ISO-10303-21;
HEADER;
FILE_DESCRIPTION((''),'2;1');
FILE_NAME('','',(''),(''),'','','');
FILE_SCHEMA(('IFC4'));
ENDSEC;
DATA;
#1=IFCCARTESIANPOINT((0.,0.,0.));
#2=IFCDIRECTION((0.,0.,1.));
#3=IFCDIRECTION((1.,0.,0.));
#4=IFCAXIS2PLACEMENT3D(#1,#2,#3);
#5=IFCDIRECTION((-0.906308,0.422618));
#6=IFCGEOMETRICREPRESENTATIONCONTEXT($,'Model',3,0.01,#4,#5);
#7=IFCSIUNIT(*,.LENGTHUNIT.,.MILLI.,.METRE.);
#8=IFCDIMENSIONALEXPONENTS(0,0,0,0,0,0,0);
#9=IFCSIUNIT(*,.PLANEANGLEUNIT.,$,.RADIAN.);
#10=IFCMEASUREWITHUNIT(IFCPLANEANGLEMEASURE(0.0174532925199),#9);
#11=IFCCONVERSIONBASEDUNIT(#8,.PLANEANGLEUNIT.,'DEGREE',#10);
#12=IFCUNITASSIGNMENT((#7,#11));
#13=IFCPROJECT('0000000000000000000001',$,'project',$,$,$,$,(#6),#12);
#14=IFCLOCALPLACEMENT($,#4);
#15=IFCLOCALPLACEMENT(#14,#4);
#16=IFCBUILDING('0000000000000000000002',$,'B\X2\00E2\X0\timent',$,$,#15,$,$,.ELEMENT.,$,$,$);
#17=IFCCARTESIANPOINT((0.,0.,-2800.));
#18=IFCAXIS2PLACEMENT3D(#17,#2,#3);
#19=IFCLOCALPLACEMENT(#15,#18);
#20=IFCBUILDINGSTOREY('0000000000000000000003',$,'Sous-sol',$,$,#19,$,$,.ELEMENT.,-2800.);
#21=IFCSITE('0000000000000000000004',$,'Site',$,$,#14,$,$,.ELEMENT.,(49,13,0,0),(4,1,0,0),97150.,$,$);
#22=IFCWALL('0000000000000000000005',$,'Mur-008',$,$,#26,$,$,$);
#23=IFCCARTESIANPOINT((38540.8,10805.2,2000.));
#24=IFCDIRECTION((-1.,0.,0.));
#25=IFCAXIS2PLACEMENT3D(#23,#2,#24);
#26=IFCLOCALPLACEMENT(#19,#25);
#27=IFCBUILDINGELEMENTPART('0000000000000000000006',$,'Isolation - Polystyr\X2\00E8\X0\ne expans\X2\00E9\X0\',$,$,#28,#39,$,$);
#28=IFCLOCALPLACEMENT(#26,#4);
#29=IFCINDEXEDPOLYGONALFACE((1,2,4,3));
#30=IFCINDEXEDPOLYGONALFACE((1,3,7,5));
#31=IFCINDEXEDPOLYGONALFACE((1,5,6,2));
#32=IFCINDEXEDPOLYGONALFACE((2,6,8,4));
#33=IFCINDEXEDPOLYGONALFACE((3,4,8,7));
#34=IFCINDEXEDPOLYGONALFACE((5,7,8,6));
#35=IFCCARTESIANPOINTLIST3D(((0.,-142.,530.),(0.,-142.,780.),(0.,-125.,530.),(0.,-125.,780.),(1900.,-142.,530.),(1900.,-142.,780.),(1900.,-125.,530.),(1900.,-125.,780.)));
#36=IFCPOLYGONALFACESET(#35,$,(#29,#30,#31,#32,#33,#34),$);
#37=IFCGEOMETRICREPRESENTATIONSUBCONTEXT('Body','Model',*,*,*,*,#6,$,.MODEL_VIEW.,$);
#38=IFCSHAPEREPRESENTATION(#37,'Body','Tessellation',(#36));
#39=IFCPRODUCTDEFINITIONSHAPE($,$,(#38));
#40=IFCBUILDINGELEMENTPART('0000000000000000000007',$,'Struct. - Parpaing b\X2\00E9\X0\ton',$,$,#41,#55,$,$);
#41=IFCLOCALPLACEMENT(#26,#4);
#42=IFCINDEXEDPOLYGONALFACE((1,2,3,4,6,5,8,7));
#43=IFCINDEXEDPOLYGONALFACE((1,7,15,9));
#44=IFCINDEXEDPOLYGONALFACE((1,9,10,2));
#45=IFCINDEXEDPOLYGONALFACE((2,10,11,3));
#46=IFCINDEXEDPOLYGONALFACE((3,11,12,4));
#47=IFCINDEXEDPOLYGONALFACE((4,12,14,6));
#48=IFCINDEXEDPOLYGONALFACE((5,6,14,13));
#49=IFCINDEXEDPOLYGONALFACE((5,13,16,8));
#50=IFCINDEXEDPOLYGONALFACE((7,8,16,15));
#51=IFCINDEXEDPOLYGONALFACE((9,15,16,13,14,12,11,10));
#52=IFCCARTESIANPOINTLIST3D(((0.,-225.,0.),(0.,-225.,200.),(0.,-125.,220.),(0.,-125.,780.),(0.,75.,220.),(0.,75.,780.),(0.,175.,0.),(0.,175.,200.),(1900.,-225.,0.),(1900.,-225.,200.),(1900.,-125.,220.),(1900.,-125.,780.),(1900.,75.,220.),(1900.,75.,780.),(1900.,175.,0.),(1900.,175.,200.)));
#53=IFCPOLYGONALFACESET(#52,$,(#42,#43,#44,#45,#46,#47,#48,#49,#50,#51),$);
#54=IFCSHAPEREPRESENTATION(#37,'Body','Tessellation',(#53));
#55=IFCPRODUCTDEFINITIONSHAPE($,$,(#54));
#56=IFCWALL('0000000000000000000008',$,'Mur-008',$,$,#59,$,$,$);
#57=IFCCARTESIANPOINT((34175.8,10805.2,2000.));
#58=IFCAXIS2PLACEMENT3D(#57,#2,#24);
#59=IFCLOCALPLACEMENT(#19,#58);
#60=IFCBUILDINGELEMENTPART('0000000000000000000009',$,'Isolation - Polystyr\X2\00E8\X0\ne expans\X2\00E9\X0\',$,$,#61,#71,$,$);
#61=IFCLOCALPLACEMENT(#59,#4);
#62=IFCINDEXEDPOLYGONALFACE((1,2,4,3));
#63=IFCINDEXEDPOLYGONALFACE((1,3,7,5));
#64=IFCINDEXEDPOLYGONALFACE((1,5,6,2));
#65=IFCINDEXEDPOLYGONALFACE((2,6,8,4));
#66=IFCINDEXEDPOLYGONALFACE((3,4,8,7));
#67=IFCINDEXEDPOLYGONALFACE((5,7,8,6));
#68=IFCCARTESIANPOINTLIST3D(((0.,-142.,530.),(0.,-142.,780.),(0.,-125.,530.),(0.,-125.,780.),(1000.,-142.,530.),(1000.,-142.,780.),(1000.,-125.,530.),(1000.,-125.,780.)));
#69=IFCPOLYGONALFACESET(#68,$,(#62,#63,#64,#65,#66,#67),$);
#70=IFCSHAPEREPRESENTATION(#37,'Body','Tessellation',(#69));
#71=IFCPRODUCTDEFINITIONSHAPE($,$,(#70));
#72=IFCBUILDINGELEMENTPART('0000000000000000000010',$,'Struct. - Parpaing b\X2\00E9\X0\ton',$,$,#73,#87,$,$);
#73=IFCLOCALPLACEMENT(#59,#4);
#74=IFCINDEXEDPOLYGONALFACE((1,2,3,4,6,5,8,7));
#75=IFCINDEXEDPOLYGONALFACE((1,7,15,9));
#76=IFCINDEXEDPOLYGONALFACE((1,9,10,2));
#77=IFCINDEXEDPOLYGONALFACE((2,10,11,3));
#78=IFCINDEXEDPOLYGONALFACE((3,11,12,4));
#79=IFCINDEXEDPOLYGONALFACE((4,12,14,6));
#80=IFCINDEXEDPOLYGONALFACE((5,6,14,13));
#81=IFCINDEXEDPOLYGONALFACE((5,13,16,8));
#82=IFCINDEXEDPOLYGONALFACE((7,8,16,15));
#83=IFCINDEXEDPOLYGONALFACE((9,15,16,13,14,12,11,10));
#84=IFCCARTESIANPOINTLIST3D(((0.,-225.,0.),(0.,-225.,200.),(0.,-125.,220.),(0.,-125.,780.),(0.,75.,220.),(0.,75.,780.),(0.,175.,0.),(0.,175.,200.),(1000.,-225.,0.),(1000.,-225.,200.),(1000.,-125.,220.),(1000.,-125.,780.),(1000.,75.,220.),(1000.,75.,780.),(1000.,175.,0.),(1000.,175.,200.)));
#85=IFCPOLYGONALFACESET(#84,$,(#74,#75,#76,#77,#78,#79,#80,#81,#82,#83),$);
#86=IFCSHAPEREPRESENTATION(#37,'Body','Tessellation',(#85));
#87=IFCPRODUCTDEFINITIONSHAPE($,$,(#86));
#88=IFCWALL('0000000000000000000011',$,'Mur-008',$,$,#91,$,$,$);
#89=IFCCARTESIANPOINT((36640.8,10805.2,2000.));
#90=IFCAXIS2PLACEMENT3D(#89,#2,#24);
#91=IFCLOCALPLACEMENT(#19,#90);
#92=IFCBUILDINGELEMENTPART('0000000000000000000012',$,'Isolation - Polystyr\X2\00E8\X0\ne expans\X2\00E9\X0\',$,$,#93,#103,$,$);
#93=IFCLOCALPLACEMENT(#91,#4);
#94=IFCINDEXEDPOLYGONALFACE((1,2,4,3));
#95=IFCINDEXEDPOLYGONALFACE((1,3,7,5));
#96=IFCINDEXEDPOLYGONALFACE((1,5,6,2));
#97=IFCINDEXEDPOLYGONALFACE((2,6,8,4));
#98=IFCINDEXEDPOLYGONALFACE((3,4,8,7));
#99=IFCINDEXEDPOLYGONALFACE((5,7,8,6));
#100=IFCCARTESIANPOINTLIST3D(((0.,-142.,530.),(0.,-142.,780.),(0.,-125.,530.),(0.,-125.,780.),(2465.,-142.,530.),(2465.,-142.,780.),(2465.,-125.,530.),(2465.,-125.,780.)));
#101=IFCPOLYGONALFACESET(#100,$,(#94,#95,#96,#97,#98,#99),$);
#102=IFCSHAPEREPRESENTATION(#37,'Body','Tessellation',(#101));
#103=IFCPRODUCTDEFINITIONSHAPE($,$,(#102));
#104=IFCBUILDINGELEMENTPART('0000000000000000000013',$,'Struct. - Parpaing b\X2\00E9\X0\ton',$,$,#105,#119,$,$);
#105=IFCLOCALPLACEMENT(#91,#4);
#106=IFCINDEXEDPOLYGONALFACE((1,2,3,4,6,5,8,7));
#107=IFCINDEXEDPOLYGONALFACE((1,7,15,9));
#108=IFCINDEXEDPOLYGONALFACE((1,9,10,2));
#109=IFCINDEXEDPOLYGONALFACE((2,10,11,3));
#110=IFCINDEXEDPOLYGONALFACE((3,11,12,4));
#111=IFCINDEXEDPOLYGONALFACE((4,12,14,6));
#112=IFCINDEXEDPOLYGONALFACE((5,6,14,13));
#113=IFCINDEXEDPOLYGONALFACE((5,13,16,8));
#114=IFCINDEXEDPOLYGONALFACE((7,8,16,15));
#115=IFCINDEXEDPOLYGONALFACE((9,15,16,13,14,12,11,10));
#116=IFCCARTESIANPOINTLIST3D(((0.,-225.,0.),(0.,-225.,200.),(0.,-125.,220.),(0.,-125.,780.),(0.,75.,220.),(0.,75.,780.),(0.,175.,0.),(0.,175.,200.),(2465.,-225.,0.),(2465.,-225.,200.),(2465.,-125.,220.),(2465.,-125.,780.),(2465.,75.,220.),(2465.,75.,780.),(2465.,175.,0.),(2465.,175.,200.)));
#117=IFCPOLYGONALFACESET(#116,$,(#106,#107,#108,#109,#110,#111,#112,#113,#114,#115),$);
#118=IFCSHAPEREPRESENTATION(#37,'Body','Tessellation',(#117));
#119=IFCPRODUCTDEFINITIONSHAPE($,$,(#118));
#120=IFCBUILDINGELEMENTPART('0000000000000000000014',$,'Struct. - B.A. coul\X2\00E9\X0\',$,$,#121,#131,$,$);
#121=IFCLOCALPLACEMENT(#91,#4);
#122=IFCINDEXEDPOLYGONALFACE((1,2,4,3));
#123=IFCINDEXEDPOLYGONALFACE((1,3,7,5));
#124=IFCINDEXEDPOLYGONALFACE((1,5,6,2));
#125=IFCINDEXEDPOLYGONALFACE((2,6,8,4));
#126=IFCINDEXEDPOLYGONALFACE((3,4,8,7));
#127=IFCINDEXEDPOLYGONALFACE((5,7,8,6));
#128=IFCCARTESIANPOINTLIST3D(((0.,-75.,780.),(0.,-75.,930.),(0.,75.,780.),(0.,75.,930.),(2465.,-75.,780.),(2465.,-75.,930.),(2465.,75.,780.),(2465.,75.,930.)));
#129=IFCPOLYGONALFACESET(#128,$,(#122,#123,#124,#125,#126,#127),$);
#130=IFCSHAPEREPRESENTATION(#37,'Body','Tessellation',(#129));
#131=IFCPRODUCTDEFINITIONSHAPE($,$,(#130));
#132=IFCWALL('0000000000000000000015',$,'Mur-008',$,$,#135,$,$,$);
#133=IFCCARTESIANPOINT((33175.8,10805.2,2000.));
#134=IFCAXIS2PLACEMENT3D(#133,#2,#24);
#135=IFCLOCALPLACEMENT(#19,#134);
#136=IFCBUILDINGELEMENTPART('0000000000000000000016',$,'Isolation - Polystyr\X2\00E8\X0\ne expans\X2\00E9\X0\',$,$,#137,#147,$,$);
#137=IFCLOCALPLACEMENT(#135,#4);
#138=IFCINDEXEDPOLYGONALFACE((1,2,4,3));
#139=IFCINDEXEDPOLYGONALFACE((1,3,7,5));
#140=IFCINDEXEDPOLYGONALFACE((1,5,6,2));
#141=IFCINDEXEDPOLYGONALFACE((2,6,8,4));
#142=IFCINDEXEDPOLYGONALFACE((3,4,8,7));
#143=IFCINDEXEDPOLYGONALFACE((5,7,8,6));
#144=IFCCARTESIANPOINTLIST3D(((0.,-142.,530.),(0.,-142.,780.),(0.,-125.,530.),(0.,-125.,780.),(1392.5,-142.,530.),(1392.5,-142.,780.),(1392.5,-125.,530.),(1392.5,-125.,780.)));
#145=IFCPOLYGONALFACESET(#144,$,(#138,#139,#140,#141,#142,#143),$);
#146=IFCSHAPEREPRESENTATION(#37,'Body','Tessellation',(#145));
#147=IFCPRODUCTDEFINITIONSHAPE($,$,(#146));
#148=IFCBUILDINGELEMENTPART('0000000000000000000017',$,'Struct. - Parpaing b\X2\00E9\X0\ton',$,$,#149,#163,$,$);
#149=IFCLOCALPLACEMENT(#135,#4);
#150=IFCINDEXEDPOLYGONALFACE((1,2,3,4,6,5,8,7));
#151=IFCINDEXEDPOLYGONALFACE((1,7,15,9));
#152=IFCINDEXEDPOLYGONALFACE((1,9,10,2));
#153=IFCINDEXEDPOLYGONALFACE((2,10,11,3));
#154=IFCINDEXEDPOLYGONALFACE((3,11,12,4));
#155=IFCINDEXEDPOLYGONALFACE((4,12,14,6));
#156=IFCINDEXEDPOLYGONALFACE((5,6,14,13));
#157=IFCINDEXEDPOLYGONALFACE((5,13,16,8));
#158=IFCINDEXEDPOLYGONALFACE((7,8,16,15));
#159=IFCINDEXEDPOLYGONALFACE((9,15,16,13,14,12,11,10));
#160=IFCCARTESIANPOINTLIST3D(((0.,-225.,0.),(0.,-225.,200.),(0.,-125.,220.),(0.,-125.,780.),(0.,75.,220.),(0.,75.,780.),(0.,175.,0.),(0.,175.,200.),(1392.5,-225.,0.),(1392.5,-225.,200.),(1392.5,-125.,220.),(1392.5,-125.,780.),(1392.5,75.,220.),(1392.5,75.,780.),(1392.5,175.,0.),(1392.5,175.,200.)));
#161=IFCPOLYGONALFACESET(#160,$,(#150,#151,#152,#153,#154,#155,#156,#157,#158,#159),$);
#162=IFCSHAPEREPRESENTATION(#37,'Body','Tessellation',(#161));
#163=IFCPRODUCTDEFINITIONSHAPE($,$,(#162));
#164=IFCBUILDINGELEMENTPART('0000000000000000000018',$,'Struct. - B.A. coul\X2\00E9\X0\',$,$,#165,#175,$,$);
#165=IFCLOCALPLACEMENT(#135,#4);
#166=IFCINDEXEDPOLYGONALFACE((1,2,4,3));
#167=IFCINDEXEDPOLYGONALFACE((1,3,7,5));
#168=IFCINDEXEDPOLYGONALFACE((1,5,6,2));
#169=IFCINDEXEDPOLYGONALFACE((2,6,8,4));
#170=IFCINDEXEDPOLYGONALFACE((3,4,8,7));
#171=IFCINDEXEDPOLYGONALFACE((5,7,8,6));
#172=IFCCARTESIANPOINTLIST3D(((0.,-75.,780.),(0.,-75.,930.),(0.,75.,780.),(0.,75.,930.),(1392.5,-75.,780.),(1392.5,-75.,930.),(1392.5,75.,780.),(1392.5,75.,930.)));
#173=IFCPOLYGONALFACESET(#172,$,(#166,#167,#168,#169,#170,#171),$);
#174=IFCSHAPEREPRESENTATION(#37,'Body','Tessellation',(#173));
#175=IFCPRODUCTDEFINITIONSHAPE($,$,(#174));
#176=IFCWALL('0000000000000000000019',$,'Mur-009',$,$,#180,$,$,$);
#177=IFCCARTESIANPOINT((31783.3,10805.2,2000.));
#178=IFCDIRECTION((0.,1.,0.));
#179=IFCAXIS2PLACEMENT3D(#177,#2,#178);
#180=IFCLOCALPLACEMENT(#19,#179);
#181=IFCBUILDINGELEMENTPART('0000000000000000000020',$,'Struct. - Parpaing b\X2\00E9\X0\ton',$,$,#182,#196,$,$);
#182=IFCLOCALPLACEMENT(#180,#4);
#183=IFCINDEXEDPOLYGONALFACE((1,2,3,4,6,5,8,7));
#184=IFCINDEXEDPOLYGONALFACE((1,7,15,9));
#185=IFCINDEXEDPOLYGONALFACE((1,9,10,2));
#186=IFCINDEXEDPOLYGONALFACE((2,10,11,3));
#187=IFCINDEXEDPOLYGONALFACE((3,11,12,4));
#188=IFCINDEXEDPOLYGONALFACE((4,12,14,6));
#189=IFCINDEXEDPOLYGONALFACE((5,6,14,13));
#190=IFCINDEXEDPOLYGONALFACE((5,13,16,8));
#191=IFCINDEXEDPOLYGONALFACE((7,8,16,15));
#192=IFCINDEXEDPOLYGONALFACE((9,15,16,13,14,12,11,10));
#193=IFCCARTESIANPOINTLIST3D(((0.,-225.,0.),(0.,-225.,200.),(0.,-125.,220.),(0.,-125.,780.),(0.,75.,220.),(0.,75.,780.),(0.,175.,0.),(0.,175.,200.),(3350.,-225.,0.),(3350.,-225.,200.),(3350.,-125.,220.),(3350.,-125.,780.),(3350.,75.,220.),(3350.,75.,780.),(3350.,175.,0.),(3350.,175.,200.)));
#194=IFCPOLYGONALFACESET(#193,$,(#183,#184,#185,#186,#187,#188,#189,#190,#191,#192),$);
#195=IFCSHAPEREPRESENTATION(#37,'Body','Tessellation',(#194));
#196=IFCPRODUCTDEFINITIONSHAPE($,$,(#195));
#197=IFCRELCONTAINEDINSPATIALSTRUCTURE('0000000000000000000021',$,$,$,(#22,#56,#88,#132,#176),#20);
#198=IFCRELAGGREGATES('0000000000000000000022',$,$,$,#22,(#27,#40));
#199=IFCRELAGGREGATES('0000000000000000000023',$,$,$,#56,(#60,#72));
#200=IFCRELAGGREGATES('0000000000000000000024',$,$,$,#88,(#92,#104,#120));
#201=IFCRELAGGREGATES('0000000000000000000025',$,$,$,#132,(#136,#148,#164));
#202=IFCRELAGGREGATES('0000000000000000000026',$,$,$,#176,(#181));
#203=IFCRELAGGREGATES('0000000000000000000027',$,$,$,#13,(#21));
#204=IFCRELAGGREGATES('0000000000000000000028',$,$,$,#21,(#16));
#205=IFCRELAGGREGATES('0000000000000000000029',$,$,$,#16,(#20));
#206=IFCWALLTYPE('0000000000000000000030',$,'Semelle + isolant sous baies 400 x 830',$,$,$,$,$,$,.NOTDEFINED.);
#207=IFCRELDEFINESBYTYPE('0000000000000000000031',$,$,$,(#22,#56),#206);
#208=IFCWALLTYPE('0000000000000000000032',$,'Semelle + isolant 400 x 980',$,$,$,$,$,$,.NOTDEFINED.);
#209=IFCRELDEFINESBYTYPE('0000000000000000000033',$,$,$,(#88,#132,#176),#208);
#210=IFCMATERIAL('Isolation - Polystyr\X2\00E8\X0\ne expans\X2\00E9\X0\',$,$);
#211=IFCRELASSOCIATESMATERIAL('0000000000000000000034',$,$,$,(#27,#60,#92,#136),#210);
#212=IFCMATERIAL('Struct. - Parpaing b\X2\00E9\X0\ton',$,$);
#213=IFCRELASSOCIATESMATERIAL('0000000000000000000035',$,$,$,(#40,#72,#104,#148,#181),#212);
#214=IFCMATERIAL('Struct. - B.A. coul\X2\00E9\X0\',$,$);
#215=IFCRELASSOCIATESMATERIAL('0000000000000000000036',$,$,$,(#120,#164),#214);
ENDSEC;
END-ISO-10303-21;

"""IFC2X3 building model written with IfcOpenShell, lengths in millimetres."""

from ifc_helpers import new_model, entity, si_unit, converted_unit, direction, frame, origin_with_axes, place, context, subcontext, project, spatial, polyline, outline, extrude, material, type_object, element, aggregate, save


model = new_model("IFC2X3")

# Units and contexts
model_context = context("Model", 3, precision=0.01, world=origin_with_axes(), true_north=direction((-0.906308, 0.422618)))
body_context = subcontext(model_context, "Body", "Model", "MODEL_VIEW")
ifc_project = project(units=[si_unit("LENGTHUNIT", "METRE", prefix="MILLI"), converted_unit("PLANEANGLEUNIT", "DEGREE", entity("IfcPlaneAngleMeasure", 0.0174532925199), si_unit("PLANEANGLEUNIT", "RADIAN"), dimensions=[0, 0, 0, 0, 0, 0, 0])], contexts=[model_context])

# Site, building, storey
site_placement = place(None, origin_with_axes())
site = spatial("IfcSite", under=ifc_project, at=site_placement, Name="Site", CompositionType="ELEMENT", RefLatitude=(49, 13, 0, 0), RefLongitude=(4, 1, 0, 0), RefElevation=97150.0)
building_placement = place(site_placement, origin_with_axes())
building = spatial("IfcBuilding", under=site, at=building_placement, Name="Bâtiment", CompositionType="ELEMENT")
storey_placement = place(building_placement, frame((0.0, 0.0, -2800.0), z_axis=(0.0, 0.0, 1.0), x_axis=(1.0, 0.0, 0.0)))
storey = spatial("IfcBuildingStorey", under=building, at=storey_placement, Name="Sous-sol", CompositionType="ELEMENT", Elevation=-2800.0)

# Walls, building element parts
wall_type_1 = type_object("IfcWallType", Name="Semelle + isolant sous baies 400 x 830", PredefinedType="NOTDEFINED")
wall_1_placement = place(storey_placement, frame((38540.8, 10805.2, 2000.0), z_axis=(0.0, 0.0, 1.0), x_axis=(-1.0, 0.0, 0.0)))
wall_1 = element("IfcWall", 1, at=wall_1_placement, inside=storey, type_object=wall_type_1, Name="Mur-008")
ifc_material_1 = material(Name="Isolation - Polystyrène expansé")
building_element_part_1_placement = place(wall_1_placement, origin_with_axes())
building_element_part_1 = element("IfcBuildingElementPart", 2, at=building_element_part_1_placement, material=ifc_material_1, Name="Isolation - Polystyrène expansé", context=body_context, shape_type="SweptSolid", body=[
    extrude(outline(polyline([(125.0, 780.0), (125.0, 530.0), (142.0, 530.0), (142.0, 780.0), (125.0, 780.0)])), frame((0.0, 0.0, 0.0), z_axis=(-1.0, 0.0, 0.0), x_axis=(0.0, -1.0, 0.0)), (0.0, 0.0, -1.0), 1900.0),
])
ifc_material_2 = material(Name="Struct. - Parpaing béton")
building_element_part_2_placement = place(wall_1_placement, origin_with_axes())
building_element_part_2 = element("IfcBuildingElementPart", 3, at=building_element_part_2_placement, material=ifc_material_2, Name="Struct. - Parpaing béton", context=body_context, shape_type="SweptSolid", body=[
    extrude(outline(polyline([(-175.0, 200.0), (-175.0, 0.0), (225.0, 0.0), (225.0, 200.0), (125.0, 220.0), (125.0, 780.0), (-75.0, 780.0), (-75.0, 220.0), (-175.0, 200.0)])), frame((0.0, 0.0, 0.0), z_axis=(-1.0, 0.0, 0.0), x_axis=(0.0, -1.0, 0.0)), (0.0, 0.0, -1.0), 1900.0),
])
aggregate(wall_1, [building_element_part_1, building_element_part_2])
wall_2_placement = place(storey_placement, frame((34175.8, 10805.2, 2000.0), z_axis=(0.0, 0.0, 1.0), x_axis=(-1.0, 0.0, 0.0)))
wall_2 = element("IfcWall", 4, at=wall_2_placement, inside=storey, type_object=wall_type_1, Name="Mur-008")
building_element_part_3_placement = place(wall_2_placement, origin_with_axes())
building_element_part_3 = element("IfcBuildingElementPart", 5, at=building_element_part_3_placement, material=ifc_material_1, Name="Isolation - Polystyrène expansé", context=body_context, shape_type="SweptSolid", body=[
    extrude(outline(polyline([(125.0, 780.0), (125.0, 530.0), (142.0, 530.0), (142.0, 780.0), (125.0, 780.0)])), frame((0.0, 0.0, 0.0), z_axis=(-1.0, 0.0, 0.0), x_axis=(0.0, -1.0, 0.0)), (0.0, 0.0, -1.0), 1000.0),
])
building_element_part_4_placement = place(wall_2_placement, origin_with_axes())
building_element_part_4 = element("IfcBuildingElementPart", 6, at=building_element_part_4_placement, material=ifc_material_2, Name="Struct. - Parpaing béton", context=body_context, shape_type="SweptSolid", body=[
    extrude(outline(polyline([(-175.0, 200.0), (-175.0, 0.0), (225.0, 0.0), (225.0, 200.0), (125.0, 220.0), (125.0, 780.0), (-75.0, 780.0), (-75.0, 220.0), (-175.0, 200.0)])), frame((0.0, 0.0, 0.0), z_axis=(-1.0, 0.0, 0.0), x_axis=(0.0, -1.0, 0.0)), (0.0, 0.0, -1.0), 1000.0),
])
aggregate(wall_2, [building_element_part_3, building_element_part_4])
wall_type_2 = type_object("IfcWallType", Name="Semelle + isolant 400 x 980", PredefinedType="NOTDEFINED")
wall_3_placement = place(storey_placement, frame((36640.8, 10805.2, 2000.0), z_axis=(0.0, 0.0, 1.0), x_axis=(-1.0, 0.0, 0.0)))
wall_3 = element("IfcWall", 7, at=wall_3_placement, inside=storey, type_object=wall_type_2, Name="Mur-008")
building_element_part_5_placement = place(wall_3_placement, origin_with_axes())
building_element_part_5 = element("IfcBuildingElementPart", 8, at=building_element_part_5_placement, material=ifc_material_1, Name="Isolation - Polystyrène expansé", context=body_context, shape_type="SweptSolid", body=[
    extrude(outline(polyline([(125.0, 780.0), (125.0, 530.0), (142.0, 530.0), (142.0, 780.0), (125.0, 780.0)])), frame((0.0, 0.0, 0.0), z_axis=(-1.0, 0.0, 0.0), x_axis=(0.0, -1.0, 0.0)), (0.0, 0.0, -1.0), 2465.0),
])
building_element_part_6_placement = place(wall_3_placement, origin_with_axes())
building_element_part_6 = element("IfcBuildingElementPart", 9, at=building_element_part_6_placement, material=ifc_material_2, Name="Struct. - Parpaing béton", context=body_context, shape_type="SweptSolid", body=[
    extrude(outline(polyline([(-75.0, 220.0), (-175.0, 200.0), (-175.0, 0.0), (225.0, 0.0), (225.0, 200.0), (125.0, 220.0), (125.0, 780.0), (-75.0, 780.0), (-75.0, 220.0)])), frame((0.0, 0.0, 0.0), z_axis=(-1.0, 0.0, 0.0), x_axis=(0.0, -1.0, 0.0)), (0.0, 0.0, -1.0), 2465.0),
])
ifc_material_3 = material(Name="Struct. - B.A. coulé")
building_element_part_7_placement = place(wall_3_placement, origin_with_axes())
building_element_part_7 = element("IfcBuildingElementPart", 10, at=building_element_part_7_placement, material=ifc_material_3, Name="Struct. - B.A. coulé", context=body_context, shape_type="SweptSolid", body=[
    extrude(outline(polyline([(75.0, 780.0), (75.0, 930.0), (-75.0, 930.0), (-75.0, 780.0), (75.0, 780.0)])), frame((0.0, 0.0, 0.0), z_axis=(-1.0, 0.0, 0.0), x_axis=(0.0, -1.0, 0.0)), (0.0, 0.0, -1.0), 2465.0),
])
aggregate(wall_3, [building_element_part_5, building_element_part_6, building_element_part_7])
wall_4_placement = place(storey_placement, frame((33175.8, 10805.2, 2000.0), z_axis=(0.0, 0.0, 1.0), x_axis=(-1.0, 0.0, 0.0)))
wall_4 = element("IfcWall", 11, at=wall_4_placement, inside=storey, type_object=wall_type_2, Name="Mur-008")
building_element_part_8_placement = place(wall_4_placement, origin_with_axes())
building_element_part_8 = element("IfcBuildingElementPart", 12, at=building_element_part_8_placement, material=ifc_material_1, Name="Isolation - Polystyrène expansé", context=body_context, shape_type="SweptSolid", body=[
    extrude(outline(polyline([(125.0, 780.0), (125.0, 530.0), (142.0, 530.0), (142.0, 780.0), (125.0, 780.0)])), frame((0.0, 0.0, 0.0), z_axis=(-1.0, 0.0, 0.0), x_axis=(0.0, -1.0, 0.0)), (0.0, 0.0, -1.0), 1392.5),
])
building_element_part_9_placement = place(wall_4_placement, origin_with_axes())
building_element_part_9 = element("IfcBuildingElementPart", 13, at=building_element_part_9_placement, material=ifc_material_2, Name="Struct. - Parpaing béton", context=body_context, shape_type="SweptSolid", body=[
    extrude(outline(polyline([(-75.0, 220.0), (-175.0, 200.0), (-175.0, 0.0), (225.0, 0.0), (225.0, 200.0), (125.0, 220.0), (125.0, 780.0), (-75.0, 780.0), (-75.0, 220.0)])), frame((0.0, 0.0, 0.0), z_axis=(-1.0, 0.0, 0.0), x_axis=(0.0, -1.0, 0.0)), (0.0, 0.0, -1.0), 1392.5),
])
building_element_part_10_placement = place(wall_4_placement, origin_with_axes())
building_element_part_10 = element("IfcBuildingElementPart", 14, at=building_element_part_10_placement, material=ifc_material_3, Name="Struct. - B.A. coulé", context=body_context, shape_type="SweptSolid", body=[
    extrude(outline(polyline([(75.0, 780.0), (75.0, 930.0), (-75.0, 930.0), (-75.0, 780.0), (75.0, 780.0)])), frame((0.0, 0.0, 0.0), z_axis=(-1.0, 0.0, 0.0), x_axis=(0.0, -1.0, 0.0)), (0.0, 0.0, -1.0), 1392.5),
])
aggregate(wall_4, [building_element_part_8, building_element_part_9, building_element_part_10])
wall_5_placement = place(storey_placement, frame((31783.3, 10805.2, 2000.0), z_axis=(0.0, 0.0, 1.0), x_axis=(0.0, 1.0, 0.0)))
wall_5 = element("IfcWall", 15, at=wall_5_placement, inside=storey, type_object=wall_type_2, Name="Mur-009")
building_element_part_11_placement = place(wall_5_placement, origin_with_axes())
building_element_part_11 = element("IfcBuildingElementPart", 16, at=building_element_part_11_placement, material=ifc_material_2, Name="Struct. - Parpaing béton", context=body_context, shape_type="SweptSolid", body=[
    extrude(outline(polyline([(-75.0, 220.0), (-175.0, 200.0), (-175.0, 0.0), (225.0, 0.0), (225.0, 200.0), (125.0, 220.0), (125.0, 780.0), (-75.0, 780.0), (-75.0, 220.0)])), frame((0.0, 0.0, 0.0), z_axis=(-1.0, 0.0, 0.0), x_axis=(0.0, -1.0, 0.0)), (0.0, 0.0, -1.0), 3350.0),
])
aggregate(wall_5, [building_element_part_11])

save(model, "model.ifc")
